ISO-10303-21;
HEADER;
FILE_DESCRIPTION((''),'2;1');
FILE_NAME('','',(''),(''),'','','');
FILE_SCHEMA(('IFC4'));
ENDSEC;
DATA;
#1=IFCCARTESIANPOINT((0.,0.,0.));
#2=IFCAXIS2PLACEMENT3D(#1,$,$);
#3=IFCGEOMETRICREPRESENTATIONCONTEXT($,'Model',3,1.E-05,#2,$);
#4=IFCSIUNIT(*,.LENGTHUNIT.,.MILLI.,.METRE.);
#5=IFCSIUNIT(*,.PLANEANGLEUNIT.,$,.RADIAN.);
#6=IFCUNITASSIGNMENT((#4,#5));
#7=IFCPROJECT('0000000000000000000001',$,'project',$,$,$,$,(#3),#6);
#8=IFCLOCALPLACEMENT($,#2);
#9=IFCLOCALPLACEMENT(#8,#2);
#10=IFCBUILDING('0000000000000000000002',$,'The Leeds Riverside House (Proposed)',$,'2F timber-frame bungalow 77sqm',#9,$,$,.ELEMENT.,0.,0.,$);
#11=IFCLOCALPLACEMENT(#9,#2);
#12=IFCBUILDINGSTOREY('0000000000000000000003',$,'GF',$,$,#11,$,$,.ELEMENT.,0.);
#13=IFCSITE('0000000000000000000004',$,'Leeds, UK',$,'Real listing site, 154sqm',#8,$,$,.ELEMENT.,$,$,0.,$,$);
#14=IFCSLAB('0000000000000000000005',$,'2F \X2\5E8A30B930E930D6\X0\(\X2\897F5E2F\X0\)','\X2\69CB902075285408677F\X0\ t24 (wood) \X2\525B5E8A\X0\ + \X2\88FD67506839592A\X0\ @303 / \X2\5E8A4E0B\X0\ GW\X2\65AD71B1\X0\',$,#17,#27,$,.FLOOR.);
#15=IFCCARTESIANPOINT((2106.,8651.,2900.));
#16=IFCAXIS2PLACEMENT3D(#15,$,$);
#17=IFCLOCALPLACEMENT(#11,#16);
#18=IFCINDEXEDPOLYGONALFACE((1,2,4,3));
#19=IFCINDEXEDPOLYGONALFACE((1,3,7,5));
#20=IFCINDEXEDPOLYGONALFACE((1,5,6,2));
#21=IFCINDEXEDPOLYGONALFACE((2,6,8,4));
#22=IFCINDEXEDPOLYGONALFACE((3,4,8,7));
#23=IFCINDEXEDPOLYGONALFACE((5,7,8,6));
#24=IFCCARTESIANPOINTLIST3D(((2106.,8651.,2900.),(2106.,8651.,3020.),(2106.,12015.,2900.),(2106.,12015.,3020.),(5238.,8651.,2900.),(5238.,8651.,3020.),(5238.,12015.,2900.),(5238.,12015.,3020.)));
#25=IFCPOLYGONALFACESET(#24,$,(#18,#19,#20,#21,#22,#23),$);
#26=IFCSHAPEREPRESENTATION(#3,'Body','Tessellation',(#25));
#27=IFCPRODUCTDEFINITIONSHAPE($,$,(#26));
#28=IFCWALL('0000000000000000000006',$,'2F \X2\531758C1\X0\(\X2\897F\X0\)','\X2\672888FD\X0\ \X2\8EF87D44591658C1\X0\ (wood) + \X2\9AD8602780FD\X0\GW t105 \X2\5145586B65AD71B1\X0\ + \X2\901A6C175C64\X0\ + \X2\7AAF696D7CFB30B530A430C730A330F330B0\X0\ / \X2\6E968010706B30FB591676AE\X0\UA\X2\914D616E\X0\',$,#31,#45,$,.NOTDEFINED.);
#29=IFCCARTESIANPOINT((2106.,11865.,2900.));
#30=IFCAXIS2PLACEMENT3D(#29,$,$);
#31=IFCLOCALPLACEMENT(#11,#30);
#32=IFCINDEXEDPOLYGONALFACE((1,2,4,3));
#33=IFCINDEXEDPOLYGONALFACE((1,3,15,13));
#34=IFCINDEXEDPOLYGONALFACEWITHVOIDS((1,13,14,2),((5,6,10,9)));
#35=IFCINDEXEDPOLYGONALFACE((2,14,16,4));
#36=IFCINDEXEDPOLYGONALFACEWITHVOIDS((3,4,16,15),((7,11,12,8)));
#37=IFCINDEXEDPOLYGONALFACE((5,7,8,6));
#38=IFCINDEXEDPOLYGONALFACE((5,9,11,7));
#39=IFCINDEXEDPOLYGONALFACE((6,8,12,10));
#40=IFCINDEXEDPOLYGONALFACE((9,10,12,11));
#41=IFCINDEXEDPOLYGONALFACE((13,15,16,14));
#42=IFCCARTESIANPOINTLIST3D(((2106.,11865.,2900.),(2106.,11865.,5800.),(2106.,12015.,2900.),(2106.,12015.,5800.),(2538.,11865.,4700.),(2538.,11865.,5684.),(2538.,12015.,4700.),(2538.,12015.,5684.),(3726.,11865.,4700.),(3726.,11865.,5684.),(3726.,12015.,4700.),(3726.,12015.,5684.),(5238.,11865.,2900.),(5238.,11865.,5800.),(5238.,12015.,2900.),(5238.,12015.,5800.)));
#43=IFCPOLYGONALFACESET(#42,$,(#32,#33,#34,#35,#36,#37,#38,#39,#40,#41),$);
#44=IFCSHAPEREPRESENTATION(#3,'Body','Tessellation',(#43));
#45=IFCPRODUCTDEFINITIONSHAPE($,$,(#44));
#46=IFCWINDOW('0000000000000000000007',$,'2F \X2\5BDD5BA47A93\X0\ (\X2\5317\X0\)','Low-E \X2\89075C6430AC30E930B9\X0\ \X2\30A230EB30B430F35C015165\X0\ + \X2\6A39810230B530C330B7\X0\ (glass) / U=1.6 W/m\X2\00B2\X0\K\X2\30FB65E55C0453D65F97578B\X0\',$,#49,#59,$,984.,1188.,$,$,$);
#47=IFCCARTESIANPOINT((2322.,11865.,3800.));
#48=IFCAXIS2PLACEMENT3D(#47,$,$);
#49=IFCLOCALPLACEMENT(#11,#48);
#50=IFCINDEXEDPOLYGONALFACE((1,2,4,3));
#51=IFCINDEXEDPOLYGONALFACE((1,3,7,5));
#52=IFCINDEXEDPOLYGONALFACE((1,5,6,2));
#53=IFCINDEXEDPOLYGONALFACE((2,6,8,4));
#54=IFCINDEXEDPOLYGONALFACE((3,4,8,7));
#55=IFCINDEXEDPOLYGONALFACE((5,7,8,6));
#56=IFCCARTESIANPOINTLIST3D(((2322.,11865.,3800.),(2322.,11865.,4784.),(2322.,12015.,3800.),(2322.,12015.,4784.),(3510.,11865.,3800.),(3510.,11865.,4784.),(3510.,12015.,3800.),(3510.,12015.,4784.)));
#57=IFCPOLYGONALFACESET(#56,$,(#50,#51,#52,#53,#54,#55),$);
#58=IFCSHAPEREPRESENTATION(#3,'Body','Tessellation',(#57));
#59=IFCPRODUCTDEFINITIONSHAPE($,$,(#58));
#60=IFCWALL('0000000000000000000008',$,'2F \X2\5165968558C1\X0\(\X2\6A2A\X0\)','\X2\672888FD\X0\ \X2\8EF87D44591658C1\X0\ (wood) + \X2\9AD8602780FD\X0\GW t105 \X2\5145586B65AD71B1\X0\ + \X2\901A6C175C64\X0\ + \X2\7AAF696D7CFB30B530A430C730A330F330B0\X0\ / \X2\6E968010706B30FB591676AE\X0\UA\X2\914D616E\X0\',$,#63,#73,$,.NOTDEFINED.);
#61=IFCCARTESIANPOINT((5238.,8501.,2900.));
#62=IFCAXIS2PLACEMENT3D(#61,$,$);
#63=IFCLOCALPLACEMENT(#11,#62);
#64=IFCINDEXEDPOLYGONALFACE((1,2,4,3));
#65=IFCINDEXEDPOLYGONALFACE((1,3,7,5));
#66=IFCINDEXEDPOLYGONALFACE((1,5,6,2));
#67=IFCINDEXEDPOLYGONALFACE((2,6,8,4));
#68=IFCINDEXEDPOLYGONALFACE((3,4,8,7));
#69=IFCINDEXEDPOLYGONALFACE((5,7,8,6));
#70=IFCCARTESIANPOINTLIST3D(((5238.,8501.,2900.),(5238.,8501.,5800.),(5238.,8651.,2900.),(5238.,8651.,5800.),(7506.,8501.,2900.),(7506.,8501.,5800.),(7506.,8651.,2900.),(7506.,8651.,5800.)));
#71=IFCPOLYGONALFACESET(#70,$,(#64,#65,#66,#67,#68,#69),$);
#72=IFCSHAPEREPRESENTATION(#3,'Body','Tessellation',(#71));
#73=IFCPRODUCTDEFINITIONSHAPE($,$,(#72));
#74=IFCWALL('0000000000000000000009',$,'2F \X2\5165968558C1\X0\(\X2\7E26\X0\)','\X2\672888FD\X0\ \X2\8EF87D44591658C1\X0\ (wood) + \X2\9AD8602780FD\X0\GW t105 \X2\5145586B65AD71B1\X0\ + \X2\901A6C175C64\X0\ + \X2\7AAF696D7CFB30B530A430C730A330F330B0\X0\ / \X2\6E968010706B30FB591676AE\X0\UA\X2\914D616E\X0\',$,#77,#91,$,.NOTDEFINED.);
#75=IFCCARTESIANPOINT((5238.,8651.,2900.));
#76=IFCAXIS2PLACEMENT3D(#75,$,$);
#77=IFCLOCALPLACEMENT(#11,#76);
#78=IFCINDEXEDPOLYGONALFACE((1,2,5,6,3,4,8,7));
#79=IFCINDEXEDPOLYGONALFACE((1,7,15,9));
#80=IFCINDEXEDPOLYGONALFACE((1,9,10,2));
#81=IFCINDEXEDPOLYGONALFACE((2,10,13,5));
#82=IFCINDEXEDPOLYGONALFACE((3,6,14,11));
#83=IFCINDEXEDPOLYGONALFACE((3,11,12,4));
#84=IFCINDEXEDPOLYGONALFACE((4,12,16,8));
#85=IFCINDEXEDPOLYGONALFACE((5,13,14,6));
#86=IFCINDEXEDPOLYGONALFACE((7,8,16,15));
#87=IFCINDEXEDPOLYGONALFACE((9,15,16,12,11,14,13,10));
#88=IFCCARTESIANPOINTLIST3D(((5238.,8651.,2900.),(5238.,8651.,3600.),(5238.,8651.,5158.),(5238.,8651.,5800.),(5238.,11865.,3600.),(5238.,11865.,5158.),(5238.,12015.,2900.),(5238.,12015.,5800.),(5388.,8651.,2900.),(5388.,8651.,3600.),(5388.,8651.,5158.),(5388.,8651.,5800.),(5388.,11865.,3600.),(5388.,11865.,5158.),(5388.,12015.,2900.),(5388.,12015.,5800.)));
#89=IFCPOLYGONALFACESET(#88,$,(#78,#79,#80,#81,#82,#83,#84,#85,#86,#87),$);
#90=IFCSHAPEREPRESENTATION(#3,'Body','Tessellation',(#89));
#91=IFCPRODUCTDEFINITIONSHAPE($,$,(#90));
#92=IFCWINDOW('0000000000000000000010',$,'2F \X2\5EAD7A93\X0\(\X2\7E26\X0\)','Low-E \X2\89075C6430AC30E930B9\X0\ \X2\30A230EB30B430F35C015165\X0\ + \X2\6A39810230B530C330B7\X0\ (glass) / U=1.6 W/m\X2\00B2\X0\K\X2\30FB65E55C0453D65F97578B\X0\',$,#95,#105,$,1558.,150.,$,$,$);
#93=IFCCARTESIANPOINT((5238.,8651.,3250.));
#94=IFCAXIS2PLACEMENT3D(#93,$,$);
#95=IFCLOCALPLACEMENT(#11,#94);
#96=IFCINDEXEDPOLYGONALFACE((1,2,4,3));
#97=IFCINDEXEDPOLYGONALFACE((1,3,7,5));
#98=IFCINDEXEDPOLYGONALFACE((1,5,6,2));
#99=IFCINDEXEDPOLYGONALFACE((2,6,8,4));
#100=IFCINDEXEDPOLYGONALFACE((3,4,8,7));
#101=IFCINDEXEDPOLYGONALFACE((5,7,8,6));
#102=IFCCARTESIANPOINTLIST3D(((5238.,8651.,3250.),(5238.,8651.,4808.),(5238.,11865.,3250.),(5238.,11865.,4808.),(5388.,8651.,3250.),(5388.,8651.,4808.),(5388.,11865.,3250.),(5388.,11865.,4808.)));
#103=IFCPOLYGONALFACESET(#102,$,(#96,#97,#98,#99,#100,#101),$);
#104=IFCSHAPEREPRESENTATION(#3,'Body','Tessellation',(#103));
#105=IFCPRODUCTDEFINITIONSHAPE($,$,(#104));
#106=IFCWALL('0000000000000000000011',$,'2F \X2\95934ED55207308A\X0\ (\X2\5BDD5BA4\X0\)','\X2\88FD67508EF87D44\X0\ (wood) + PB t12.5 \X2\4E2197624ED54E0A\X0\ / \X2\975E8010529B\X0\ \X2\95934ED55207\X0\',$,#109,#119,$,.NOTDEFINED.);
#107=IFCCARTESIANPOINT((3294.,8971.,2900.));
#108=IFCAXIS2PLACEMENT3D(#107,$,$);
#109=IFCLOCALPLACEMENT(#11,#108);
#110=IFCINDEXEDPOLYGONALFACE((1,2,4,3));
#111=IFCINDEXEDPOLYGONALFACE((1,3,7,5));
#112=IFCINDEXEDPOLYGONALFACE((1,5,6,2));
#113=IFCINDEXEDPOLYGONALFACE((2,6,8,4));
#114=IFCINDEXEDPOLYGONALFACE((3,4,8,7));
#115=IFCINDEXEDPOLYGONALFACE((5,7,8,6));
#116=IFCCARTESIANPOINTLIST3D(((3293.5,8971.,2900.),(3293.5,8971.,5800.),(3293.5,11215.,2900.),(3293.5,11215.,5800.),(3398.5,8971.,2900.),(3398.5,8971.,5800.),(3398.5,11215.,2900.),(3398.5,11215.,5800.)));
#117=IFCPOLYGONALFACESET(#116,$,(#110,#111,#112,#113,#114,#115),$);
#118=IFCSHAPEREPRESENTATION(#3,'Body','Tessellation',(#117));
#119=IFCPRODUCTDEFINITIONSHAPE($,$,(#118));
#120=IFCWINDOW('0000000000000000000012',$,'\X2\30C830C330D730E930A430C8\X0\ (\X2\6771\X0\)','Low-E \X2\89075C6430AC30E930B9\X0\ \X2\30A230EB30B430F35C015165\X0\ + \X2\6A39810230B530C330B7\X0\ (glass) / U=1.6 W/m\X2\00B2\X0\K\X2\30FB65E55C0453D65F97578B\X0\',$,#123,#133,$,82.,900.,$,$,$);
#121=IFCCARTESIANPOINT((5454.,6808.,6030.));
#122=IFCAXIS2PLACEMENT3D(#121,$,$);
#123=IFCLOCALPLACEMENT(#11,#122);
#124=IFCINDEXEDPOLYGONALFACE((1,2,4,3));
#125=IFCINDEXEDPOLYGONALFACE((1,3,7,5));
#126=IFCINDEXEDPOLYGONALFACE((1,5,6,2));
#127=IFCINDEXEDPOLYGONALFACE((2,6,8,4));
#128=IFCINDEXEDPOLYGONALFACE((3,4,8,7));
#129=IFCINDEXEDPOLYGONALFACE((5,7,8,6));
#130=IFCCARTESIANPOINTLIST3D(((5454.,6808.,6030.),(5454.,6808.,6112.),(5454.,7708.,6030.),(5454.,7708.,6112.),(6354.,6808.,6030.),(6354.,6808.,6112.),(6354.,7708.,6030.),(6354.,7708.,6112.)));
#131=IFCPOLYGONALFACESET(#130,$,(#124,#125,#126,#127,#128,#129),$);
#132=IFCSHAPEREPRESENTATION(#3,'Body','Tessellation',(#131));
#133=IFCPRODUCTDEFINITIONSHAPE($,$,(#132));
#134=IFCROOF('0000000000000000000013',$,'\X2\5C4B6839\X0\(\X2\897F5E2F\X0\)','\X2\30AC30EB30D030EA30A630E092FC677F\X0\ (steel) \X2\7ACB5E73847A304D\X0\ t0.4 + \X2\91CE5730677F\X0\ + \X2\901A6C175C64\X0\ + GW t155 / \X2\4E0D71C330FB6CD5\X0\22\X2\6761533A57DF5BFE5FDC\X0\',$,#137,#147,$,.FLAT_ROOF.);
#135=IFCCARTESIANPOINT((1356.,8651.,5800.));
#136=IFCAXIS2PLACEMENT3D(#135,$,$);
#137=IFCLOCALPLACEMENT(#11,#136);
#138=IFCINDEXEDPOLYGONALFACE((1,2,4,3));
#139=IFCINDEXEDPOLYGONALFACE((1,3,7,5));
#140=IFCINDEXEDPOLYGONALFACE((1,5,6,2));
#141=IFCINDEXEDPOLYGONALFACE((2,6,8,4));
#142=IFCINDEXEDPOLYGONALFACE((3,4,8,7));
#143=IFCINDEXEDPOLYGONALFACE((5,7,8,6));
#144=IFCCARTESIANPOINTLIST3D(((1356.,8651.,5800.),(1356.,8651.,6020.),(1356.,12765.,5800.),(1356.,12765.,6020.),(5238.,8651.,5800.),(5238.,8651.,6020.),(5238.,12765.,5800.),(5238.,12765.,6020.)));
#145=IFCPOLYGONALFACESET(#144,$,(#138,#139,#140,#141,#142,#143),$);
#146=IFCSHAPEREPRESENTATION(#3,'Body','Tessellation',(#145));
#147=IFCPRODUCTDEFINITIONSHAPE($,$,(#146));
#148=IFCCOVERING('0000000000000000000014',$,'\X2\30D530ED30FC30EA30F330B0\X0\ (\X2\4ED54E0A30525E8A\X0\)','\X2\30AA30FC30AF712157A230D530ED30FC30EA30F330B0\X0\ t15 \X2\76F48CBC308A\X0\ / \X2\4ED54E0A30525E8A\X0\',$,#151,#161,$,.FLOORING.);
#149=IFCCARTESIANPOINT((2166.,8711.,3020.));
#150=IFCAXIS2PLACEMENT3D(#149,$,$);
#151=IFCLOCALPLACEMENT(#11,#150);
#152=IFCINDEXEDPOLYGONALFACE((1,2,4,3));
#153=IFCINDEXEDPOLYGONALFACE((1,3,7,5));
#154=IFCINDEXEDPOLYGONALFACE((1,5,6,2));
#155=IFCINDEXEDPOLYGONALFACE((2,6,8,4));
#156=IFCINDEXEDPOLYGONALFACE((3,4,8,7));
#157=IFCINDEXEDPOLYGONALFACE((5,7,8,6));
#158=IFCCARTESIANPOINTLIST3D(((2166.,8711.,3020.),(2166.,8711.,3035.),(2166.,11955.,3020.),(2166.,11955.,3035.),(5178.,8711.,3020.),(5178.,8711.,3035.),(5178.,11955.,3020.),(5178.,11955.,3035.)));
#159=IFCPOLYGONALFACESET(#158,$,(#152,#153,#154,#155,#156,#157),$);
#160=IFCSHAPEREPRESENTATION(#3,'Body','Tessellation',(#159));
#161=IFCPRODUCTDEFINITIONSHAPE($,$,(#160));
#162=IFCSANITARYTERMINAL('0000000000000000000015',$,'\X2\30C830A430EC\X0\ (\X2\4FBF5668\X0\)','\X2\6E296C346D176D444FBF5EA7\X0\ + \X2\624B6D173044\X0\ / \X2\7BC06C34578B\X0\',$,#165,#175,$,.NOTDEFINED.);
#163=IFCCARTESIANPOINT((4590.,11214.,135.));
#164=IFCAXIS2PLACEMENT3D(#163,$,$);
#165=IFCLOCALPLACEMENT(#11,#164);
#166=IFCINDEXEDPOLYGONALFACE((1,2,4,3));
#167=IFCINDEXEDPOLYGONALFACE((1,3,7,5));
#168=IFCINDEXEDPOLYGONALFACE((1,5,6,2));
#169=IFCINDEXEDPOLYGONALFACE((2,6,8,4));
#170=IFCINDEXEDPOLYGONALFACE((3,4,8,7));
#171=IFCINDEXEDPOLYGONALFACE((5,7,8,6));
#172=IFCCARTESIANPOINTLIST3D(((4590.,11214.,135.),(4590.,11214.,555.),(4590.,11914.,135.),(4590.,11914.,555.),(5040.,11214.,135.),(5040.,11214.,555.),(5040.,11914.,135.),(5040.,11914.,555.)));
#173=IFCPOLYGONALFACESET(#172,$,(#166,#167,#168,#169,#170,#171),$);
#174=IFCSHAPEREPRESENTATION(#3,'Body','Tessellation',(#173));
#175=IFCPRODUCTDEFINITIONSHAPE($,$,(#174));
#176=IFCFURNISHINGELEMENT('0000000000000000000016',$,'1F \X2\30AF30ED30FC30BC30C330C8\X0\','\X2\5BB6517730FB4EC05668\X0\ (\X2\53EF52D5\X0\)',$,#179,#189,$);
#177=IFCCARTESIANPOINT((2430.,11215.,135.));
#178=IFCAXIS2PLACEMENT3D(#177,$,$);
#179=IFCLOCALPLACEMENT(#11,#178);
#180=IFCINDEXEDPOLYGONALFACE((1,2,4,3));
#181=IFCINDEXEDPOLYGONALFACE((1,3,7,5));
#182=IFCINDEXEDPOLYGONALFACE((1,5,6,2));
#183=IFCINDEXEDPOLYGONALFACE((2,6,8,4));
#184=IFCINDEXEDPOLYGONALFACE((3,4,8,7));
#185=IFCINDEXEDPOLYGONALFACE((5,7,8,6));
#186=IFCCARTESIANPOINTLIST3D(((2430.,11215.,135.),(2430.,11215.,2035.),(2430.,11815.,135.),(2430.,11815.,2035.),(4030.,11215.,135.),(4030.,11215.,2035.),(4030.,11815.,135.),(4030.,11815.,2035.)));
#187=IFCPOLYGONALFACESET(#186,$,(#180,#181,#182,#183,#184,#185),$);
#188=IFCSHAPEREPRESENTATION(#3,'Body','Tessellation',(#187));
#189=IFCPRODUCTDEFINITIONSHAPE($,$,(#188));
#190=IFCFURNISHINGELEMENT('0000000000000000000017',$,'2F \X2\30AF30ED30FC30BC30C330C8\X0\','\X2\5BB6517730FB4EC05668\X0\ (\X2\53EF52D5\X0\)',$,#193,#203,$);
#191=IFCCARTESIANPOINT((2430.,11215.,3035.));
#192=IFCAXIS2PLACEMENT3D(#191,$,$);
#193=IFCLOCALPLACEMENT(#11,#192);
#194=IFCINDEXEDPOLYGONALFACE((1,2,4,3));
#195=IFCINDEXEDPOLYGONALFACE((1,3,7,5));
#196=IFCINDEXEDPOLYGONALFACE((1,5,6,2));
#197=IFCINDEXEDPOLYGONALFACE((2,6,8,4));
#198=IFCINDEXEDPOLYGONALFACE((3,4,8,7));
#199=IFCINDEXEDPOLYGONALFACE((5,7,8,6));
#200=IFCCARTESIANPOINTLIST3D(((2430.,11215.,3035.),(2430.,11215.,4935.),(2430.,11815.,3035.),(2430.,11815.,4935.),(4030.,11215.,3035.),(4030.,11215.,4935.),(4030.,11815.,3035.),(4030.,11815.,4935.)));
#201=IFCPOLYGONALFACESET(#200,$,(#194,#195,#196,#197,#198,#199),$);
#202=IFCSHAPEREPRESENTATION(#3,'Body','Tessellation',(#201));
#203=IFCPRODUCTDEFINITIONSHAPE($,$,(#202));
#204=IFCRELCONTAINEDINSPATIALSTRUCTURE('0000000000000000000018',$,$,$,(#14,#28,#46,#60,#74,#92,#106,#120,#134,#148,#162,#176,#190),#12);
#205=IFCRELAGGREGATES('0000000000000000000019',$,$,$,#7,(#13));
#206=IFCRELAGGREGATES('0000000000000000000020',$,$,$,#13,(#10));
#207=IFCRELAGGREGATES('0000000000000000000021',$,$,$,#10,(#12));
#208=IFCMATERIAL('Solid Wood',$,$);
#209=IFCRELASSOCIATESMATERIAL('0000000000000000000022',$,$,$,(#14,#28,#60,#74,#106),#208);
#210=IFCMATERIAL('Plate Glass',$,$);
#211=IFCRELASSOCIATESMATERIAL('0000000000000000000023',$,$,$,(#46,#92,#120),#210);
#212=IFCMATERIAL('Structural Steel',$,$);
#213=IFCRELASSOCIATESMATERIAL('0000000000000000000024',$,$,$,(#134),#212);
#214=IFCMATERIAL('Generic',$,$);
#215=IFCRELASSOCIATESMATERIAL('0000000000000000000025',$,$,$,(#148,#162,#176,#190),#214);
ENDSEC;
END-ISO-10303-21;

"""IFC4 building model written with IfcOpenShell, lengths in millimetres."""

from ifc_helpers import new_model, si_unit, frame, frame_2d, origin, place, context, project, spatial, rectangle, extrude, material, element, fill, save


model = new_model("IFC4")

# Units and contexts
model_context = context("Model", 3, precision=1e-05, world=origin())
ifc_project = project(units=[si_unit("LENGTHUNIT", "METRE", prefix="MILLI"), si_unit("PLANEANGLEUNIT", "RADIAN")], contexts=[model_context])

# Site, building, storey
site_placement = place(None, origin())
site = spatial("IfcSite", under=ifc_project, at=site_placement, Name="Leeds, UK", ObjectType="Real listing site, 154sqm", CompositionType="ELEMENT", RefElevation=0.0)
building_placement = place(site_placement, origin())
building = spatial("IfcBuilding", under=site, at=building_placement, Name="The Leeds Riverside House (Proposed)", ObjectType="2F timber-frame bungalow 77sqm", CompositionType="ELEMENT", ElevationOfRefHeight=0.0, ElevationOfTerrain=0.0)
storey_placement = place(building_placement, origin())
storey = spatial("IfcBuildingStorey", under=building, at=storey_placement, Name="GF", CompositionType="ELEMENT", Elevation=0.0)

# Slab
ifc_material_1 = material(Name="Solid Wood")
slab_placement = place(storey_placement, frame((2106.0, 8651.0, 2900.0)))
element("IfcSlab", 1, at=slab_placement, inside=storey, material=ifc_material_1, Name="2F 床スラブ(西帯)", Description="構造用合板 t24 (wood) 剛床 + 製材根太 @303 / 床下 GW断熱", PredefinedType="FLOOR", context=model_context, shape_type="SweptSolid", body=[
    extrude(rectangle(XDim=3132.0, YDim=3364.0, at=frame_2d((1566.0, 1682.0))), frame((2106.0, 8651.0, 2900.0)), (0.0, 0.0, 1.0), 120.0),
])

# Wall, opening, window
wall_1_placement = place(storey_placement, frame((2106.0, 11865.0, 2900.0)))
wall_1 = element("IfcWall", 2, at=wall_1_placement, inside=storey, material=ifc_material_1, Name="2F 北壁(西)", Description="木製 軸組外壁 (wood) + 高性能GW t105 充填断熱 + 通気層 + 窯業系サイディング / 準耐火・外皮UA配慮", PredefinedType="NOTDEFINED", context=model_context, shape_type="SweptSolid", body=[
    extrude(rectangle(XDim=3132.0, YDim=150.0, at=frame_2d((1566.0, 75.0))), frame((2106.0, 11865.0, 2900.0)), (0.0, 0.0, 1.0), 2900.0),
])
opening_1_placement = place(storey_placement, frame((2322.0, 11865.0, 3800.0)))
opening_1 = element("IfcOpeningElement", 3, at=opening_1_placement, cuts=wall_1, PredefinedType="NOTDEFINED", context=model_context, shape_type="SweptSolid", body=[
    extrude(rectangle(XDim=1188.0, YDim=150.0, at=frame_2d((594.0, 75.0))), frame((2322.0, 11865.0, 3800.0)), (0.0, 0.0, 1.0), 984.0),
])
ifc_material_2 = material(Name="Plate Glass")
window_1_placement = place(storey_placement, frame((2322.0, 11865.0, 3800.0)))
window_1 = element("IfcWindow", 4, at=window_1_placement, inside=storey, material=ifc_material_2, Name="2F 寝室窓 (北)", Description="Low-E 複層ガラス アルゴン封入 + 樹脂サッシ (glass) / U=1.6 W/m²K・日射取得型", OverallHeight=984.0, OverallWidth=1188.0, context=model_context, shape_type="SweptSolid", body=[
    extrude(rectangle(XDim=1188.0, YDim=150.0, at=frame_2d((594.0, 75.0))), frame((2322.0, 11865.0, 3800.0)), (0.0, 0.0, 1.0), 984.0),
])
fill(opening_1, window_1)

# Wall
wall_2_placement = place(storey_placement, frame((5238.0, 8501.0, 2900.0)))
element("IfcWall", 5, at=wall_2_placement, inside=storey, material=ifc_material_1, Name="2F 入隅壁(横)", Description="木製 軸組外壁 (wood) + 高性能GW t105 充填断熱 + 通気層 + 窯業系サイディング / 準耐火・外皮UA配慮", PredefinedType="NOTDEFINED", context=model_context, shape_type="SweptSolid", body=[
    extrude(rectangle(XDim=2268.0, YDim=150.0, at=frame_2d((1134.0, 75.0))), frame((5238.0, 8501.0, 2900.0)), (0.0, 0.0, 1.0), 2900.0),
])

# Wall, opening, window
wall_3_placement = place(storey_placement, frame((5238.0, 8651.0, 2900.0)))
wall_3 = element("IfcWall", 6, at=wall_3_placement, inside=storey, material=ifc_material_1, Name="2F 入隅壁(縦)", Description="木製 軸組外壁 (wood) + 高性能GW t105 充填断熱 + 通気層 + 窯業系サイディング / 準耐火・外皮UA配慮", PredefinedType="NOTDEFINED", context=model_context, shape_type="SweptSolid", body=[
    extrude(rectangle(XDim=150.0, YDim=3364.0, at=frame_2d((75.0, 1682.0))), frame((5238.0, 8651.0, 2900.0)), (0.0, 0.0, 1.0), 2900.0),
])
opening_2_placement = place(storey_placement, frame((5238.0, 8651.0, 3250.0)))
opening_2 = element("IfcOpeningElement", 7, at=opening_2_placement, cuts=wall_3, PredefinedType="NOTDEFINED", context=model_context, shape_type="SweptSolid", body=[
    extrude(rectangle(XDim=150.0, YDim=3214.0, at=frame_2d((75.0, 1607.0))), frame((5238.0, 8651.0, 3250.0)), (0.0, 0.0, 1.0), 1558.0),
])
window_2_placement = place(storey_placement, frame((5238.0, 8651.0, 3250.0)))
window_2 = element("IfcWindow", 8, at=window_2_placement, inside=storey, material=ifc_material_2, Name="2F 庭窓(縦)", Description="Low-E 複層ガラス アルゴン封入 + 樹脂サッシ (glass) / U=1.6 W/m²K・日射取得型", OverallHeight=1558.0, OverallWidth=150.0, context=model_context, shape_type="SweptSolid", body=[
    extrude(rectangle(XDim=150.0, YDim=3214.0, at=frame_2d((75.0, 1607.0))), frame((5238.0, 8651.0, 3250.0)), (0.0, 0.0, 1.0), 1558.0),
])
fill(opening_2, window_2)

# Wall
wall_4_placement = place(storey_placement, frame((3294.0, 8971.0, 2900.0)))
element("IfcWall", 9, at=wall_4_placement, inside=storey, material=ifc_material_1, Name="2F 間仕切り (寝室)", Description="製材軸組 (wood) + PB t12.5 両面仕上 / 非耐力 間仕切", PredefinedType="NOTDEFINED", context=model_context, shape_type="SweptSolid", body=[
    extrude(rectangle(XDim=105.0, YDim=2244.0, at=frame_2d((52.0, 1122.0))), frame((3294.0, 8971.0, 2900.0)), (0.0, 0.0, 1.0), 2900.0),
])

# Window
window_3_placement = place(storey_placement, frame((5454.0, 6808.0, 6030.0)))
element("IfcWindow", 10, at=window_3_placement, inside=storey, material=ifc_material_2, Name="トップライト (東)", Description="Low-E 複層ガラス アルゴン封入 + 樹脂サッシ (glass) / U=1.6 W/m²K・日射取得型", OverallHeight=82.0, OverallWidth=900.0, context=model_context, shape_type="SweptSolid", body=[
    extrude(rectangle(XDim=900.0, YDim=900.0, at=frame_2d((450.0, 450.0))), frame((5454.0, 6808.0, 6030.0)), (0.0, 0.0, 1.0), 82.0),
])

# Roof
ifc_material_3 = material(Name="Structural Steel")
for number, where, name in (
    (11, (1356.0, 8651.0, 5800.0), "屋根(西帯)"),
):
    element("IfcRoof", number, at=place(storey_placement, frame(where)), inside=storey, material=ifc_material_3, Name=name, Description="ガルバリウム鋼板 (steel) 立平葺き t0.4 + 野地板 + 通気層 + GW t155 / 不燃・法22条区域対応", PredefinedType="FLAT_ROOF", context=model_context, shape_type="SweptSolid", body=[
        extrude(rectangle(XDim=3882.0, YDim=4114.0, at=frame_2d((1941.0, 2057.0))), frame((1356.0, 8651.0, 5800.0)), (0.0, 0.0, 1.0), 220.0),
    ])

# Covering
ifc_material_4 = material(Name="Generic")
covering_placement = place(storey_placement, frame((2166.0, 8711.0, 3020.0)))
element("IfcCovering", 12, at=covering_placement, inside=storey, material=ifc_material_4, Name="フローリング (仕上げ床)", Description="オーク無垢フローリング t15 直貼り / 仕上げ床", PredefinedType="FLOORING", context=model_context, shape_type="SweptSolid", body=[
    extrude(rectangle(XDim=3012.0, YDim=3244.0, at=frame_2d((1506.0, 1622.0))), frame((2166.0, 8711.0, 3020.0)), (0.0, 0.0, 1.0), 15.0),
])

# Sanitary terminal
sanitary_terminal_placement = place(storey_placement, frame((4590.0, 11214.0, 135.0)))
element("IfcSanitaryTerminal", 13, at=sanitary_terminal_placement, inside=storey, material=ifc_material_4, Name="トイレ (便器)", Description="温水洗浄便座 + 手洗い / 節水型", PredefinedType="NOTDEFINED", context=model_context, shape_type="SweptSolid", body=[
    extrude(rectangle(XDim=450.0, YDim=700.0, at=frame_2d((225.0, 350.0))), frame((4590.0, 11214.0, 135.0)), (0.0, 0.0, 1.0), 420.0),
])

# Furnishing elements
furnishing_1_placement = place(storey_placement, frame((2430.0, 11215.0, 135.0)))
element("IfcFurnishingElement", 14, at=furnishing_1_placement, inside=storey, material=ifc_material_4, Name="1F クローゼット", Description="家具・什器 (可動)", context=model_context, shape_type="SweptSolid", body=[
    extrude(rectangle(XDim=1600.0, YDim=600.0, at=frame_2d((800.0, 300.0))), frame((2430.0, 11215.0, 135.0)), (0.0, 0.0, 1.0), 1900.0),
])
furnishing_2_placement = place(storey_placement, frame((2430.0, 11215.0, 3035.0)))
element("IfcFurnishingElement", 15, at=furnishing_2_placement, inside=storey, material=ifc_material_4, Name="2F クローゼット", Description="家具・什器 (可動)", context=model_context, shape_type="SweptSolid", body=[
    extrude(rectangle(XDim=1600.0, YDim=600.0, at=frame_2d((800.0, 300.0))), frame((2430.0, 11215.0, 3035.0)), (0.0, 0.0, 1.0), 1900.0),
])

save(model, "model.ifc")
